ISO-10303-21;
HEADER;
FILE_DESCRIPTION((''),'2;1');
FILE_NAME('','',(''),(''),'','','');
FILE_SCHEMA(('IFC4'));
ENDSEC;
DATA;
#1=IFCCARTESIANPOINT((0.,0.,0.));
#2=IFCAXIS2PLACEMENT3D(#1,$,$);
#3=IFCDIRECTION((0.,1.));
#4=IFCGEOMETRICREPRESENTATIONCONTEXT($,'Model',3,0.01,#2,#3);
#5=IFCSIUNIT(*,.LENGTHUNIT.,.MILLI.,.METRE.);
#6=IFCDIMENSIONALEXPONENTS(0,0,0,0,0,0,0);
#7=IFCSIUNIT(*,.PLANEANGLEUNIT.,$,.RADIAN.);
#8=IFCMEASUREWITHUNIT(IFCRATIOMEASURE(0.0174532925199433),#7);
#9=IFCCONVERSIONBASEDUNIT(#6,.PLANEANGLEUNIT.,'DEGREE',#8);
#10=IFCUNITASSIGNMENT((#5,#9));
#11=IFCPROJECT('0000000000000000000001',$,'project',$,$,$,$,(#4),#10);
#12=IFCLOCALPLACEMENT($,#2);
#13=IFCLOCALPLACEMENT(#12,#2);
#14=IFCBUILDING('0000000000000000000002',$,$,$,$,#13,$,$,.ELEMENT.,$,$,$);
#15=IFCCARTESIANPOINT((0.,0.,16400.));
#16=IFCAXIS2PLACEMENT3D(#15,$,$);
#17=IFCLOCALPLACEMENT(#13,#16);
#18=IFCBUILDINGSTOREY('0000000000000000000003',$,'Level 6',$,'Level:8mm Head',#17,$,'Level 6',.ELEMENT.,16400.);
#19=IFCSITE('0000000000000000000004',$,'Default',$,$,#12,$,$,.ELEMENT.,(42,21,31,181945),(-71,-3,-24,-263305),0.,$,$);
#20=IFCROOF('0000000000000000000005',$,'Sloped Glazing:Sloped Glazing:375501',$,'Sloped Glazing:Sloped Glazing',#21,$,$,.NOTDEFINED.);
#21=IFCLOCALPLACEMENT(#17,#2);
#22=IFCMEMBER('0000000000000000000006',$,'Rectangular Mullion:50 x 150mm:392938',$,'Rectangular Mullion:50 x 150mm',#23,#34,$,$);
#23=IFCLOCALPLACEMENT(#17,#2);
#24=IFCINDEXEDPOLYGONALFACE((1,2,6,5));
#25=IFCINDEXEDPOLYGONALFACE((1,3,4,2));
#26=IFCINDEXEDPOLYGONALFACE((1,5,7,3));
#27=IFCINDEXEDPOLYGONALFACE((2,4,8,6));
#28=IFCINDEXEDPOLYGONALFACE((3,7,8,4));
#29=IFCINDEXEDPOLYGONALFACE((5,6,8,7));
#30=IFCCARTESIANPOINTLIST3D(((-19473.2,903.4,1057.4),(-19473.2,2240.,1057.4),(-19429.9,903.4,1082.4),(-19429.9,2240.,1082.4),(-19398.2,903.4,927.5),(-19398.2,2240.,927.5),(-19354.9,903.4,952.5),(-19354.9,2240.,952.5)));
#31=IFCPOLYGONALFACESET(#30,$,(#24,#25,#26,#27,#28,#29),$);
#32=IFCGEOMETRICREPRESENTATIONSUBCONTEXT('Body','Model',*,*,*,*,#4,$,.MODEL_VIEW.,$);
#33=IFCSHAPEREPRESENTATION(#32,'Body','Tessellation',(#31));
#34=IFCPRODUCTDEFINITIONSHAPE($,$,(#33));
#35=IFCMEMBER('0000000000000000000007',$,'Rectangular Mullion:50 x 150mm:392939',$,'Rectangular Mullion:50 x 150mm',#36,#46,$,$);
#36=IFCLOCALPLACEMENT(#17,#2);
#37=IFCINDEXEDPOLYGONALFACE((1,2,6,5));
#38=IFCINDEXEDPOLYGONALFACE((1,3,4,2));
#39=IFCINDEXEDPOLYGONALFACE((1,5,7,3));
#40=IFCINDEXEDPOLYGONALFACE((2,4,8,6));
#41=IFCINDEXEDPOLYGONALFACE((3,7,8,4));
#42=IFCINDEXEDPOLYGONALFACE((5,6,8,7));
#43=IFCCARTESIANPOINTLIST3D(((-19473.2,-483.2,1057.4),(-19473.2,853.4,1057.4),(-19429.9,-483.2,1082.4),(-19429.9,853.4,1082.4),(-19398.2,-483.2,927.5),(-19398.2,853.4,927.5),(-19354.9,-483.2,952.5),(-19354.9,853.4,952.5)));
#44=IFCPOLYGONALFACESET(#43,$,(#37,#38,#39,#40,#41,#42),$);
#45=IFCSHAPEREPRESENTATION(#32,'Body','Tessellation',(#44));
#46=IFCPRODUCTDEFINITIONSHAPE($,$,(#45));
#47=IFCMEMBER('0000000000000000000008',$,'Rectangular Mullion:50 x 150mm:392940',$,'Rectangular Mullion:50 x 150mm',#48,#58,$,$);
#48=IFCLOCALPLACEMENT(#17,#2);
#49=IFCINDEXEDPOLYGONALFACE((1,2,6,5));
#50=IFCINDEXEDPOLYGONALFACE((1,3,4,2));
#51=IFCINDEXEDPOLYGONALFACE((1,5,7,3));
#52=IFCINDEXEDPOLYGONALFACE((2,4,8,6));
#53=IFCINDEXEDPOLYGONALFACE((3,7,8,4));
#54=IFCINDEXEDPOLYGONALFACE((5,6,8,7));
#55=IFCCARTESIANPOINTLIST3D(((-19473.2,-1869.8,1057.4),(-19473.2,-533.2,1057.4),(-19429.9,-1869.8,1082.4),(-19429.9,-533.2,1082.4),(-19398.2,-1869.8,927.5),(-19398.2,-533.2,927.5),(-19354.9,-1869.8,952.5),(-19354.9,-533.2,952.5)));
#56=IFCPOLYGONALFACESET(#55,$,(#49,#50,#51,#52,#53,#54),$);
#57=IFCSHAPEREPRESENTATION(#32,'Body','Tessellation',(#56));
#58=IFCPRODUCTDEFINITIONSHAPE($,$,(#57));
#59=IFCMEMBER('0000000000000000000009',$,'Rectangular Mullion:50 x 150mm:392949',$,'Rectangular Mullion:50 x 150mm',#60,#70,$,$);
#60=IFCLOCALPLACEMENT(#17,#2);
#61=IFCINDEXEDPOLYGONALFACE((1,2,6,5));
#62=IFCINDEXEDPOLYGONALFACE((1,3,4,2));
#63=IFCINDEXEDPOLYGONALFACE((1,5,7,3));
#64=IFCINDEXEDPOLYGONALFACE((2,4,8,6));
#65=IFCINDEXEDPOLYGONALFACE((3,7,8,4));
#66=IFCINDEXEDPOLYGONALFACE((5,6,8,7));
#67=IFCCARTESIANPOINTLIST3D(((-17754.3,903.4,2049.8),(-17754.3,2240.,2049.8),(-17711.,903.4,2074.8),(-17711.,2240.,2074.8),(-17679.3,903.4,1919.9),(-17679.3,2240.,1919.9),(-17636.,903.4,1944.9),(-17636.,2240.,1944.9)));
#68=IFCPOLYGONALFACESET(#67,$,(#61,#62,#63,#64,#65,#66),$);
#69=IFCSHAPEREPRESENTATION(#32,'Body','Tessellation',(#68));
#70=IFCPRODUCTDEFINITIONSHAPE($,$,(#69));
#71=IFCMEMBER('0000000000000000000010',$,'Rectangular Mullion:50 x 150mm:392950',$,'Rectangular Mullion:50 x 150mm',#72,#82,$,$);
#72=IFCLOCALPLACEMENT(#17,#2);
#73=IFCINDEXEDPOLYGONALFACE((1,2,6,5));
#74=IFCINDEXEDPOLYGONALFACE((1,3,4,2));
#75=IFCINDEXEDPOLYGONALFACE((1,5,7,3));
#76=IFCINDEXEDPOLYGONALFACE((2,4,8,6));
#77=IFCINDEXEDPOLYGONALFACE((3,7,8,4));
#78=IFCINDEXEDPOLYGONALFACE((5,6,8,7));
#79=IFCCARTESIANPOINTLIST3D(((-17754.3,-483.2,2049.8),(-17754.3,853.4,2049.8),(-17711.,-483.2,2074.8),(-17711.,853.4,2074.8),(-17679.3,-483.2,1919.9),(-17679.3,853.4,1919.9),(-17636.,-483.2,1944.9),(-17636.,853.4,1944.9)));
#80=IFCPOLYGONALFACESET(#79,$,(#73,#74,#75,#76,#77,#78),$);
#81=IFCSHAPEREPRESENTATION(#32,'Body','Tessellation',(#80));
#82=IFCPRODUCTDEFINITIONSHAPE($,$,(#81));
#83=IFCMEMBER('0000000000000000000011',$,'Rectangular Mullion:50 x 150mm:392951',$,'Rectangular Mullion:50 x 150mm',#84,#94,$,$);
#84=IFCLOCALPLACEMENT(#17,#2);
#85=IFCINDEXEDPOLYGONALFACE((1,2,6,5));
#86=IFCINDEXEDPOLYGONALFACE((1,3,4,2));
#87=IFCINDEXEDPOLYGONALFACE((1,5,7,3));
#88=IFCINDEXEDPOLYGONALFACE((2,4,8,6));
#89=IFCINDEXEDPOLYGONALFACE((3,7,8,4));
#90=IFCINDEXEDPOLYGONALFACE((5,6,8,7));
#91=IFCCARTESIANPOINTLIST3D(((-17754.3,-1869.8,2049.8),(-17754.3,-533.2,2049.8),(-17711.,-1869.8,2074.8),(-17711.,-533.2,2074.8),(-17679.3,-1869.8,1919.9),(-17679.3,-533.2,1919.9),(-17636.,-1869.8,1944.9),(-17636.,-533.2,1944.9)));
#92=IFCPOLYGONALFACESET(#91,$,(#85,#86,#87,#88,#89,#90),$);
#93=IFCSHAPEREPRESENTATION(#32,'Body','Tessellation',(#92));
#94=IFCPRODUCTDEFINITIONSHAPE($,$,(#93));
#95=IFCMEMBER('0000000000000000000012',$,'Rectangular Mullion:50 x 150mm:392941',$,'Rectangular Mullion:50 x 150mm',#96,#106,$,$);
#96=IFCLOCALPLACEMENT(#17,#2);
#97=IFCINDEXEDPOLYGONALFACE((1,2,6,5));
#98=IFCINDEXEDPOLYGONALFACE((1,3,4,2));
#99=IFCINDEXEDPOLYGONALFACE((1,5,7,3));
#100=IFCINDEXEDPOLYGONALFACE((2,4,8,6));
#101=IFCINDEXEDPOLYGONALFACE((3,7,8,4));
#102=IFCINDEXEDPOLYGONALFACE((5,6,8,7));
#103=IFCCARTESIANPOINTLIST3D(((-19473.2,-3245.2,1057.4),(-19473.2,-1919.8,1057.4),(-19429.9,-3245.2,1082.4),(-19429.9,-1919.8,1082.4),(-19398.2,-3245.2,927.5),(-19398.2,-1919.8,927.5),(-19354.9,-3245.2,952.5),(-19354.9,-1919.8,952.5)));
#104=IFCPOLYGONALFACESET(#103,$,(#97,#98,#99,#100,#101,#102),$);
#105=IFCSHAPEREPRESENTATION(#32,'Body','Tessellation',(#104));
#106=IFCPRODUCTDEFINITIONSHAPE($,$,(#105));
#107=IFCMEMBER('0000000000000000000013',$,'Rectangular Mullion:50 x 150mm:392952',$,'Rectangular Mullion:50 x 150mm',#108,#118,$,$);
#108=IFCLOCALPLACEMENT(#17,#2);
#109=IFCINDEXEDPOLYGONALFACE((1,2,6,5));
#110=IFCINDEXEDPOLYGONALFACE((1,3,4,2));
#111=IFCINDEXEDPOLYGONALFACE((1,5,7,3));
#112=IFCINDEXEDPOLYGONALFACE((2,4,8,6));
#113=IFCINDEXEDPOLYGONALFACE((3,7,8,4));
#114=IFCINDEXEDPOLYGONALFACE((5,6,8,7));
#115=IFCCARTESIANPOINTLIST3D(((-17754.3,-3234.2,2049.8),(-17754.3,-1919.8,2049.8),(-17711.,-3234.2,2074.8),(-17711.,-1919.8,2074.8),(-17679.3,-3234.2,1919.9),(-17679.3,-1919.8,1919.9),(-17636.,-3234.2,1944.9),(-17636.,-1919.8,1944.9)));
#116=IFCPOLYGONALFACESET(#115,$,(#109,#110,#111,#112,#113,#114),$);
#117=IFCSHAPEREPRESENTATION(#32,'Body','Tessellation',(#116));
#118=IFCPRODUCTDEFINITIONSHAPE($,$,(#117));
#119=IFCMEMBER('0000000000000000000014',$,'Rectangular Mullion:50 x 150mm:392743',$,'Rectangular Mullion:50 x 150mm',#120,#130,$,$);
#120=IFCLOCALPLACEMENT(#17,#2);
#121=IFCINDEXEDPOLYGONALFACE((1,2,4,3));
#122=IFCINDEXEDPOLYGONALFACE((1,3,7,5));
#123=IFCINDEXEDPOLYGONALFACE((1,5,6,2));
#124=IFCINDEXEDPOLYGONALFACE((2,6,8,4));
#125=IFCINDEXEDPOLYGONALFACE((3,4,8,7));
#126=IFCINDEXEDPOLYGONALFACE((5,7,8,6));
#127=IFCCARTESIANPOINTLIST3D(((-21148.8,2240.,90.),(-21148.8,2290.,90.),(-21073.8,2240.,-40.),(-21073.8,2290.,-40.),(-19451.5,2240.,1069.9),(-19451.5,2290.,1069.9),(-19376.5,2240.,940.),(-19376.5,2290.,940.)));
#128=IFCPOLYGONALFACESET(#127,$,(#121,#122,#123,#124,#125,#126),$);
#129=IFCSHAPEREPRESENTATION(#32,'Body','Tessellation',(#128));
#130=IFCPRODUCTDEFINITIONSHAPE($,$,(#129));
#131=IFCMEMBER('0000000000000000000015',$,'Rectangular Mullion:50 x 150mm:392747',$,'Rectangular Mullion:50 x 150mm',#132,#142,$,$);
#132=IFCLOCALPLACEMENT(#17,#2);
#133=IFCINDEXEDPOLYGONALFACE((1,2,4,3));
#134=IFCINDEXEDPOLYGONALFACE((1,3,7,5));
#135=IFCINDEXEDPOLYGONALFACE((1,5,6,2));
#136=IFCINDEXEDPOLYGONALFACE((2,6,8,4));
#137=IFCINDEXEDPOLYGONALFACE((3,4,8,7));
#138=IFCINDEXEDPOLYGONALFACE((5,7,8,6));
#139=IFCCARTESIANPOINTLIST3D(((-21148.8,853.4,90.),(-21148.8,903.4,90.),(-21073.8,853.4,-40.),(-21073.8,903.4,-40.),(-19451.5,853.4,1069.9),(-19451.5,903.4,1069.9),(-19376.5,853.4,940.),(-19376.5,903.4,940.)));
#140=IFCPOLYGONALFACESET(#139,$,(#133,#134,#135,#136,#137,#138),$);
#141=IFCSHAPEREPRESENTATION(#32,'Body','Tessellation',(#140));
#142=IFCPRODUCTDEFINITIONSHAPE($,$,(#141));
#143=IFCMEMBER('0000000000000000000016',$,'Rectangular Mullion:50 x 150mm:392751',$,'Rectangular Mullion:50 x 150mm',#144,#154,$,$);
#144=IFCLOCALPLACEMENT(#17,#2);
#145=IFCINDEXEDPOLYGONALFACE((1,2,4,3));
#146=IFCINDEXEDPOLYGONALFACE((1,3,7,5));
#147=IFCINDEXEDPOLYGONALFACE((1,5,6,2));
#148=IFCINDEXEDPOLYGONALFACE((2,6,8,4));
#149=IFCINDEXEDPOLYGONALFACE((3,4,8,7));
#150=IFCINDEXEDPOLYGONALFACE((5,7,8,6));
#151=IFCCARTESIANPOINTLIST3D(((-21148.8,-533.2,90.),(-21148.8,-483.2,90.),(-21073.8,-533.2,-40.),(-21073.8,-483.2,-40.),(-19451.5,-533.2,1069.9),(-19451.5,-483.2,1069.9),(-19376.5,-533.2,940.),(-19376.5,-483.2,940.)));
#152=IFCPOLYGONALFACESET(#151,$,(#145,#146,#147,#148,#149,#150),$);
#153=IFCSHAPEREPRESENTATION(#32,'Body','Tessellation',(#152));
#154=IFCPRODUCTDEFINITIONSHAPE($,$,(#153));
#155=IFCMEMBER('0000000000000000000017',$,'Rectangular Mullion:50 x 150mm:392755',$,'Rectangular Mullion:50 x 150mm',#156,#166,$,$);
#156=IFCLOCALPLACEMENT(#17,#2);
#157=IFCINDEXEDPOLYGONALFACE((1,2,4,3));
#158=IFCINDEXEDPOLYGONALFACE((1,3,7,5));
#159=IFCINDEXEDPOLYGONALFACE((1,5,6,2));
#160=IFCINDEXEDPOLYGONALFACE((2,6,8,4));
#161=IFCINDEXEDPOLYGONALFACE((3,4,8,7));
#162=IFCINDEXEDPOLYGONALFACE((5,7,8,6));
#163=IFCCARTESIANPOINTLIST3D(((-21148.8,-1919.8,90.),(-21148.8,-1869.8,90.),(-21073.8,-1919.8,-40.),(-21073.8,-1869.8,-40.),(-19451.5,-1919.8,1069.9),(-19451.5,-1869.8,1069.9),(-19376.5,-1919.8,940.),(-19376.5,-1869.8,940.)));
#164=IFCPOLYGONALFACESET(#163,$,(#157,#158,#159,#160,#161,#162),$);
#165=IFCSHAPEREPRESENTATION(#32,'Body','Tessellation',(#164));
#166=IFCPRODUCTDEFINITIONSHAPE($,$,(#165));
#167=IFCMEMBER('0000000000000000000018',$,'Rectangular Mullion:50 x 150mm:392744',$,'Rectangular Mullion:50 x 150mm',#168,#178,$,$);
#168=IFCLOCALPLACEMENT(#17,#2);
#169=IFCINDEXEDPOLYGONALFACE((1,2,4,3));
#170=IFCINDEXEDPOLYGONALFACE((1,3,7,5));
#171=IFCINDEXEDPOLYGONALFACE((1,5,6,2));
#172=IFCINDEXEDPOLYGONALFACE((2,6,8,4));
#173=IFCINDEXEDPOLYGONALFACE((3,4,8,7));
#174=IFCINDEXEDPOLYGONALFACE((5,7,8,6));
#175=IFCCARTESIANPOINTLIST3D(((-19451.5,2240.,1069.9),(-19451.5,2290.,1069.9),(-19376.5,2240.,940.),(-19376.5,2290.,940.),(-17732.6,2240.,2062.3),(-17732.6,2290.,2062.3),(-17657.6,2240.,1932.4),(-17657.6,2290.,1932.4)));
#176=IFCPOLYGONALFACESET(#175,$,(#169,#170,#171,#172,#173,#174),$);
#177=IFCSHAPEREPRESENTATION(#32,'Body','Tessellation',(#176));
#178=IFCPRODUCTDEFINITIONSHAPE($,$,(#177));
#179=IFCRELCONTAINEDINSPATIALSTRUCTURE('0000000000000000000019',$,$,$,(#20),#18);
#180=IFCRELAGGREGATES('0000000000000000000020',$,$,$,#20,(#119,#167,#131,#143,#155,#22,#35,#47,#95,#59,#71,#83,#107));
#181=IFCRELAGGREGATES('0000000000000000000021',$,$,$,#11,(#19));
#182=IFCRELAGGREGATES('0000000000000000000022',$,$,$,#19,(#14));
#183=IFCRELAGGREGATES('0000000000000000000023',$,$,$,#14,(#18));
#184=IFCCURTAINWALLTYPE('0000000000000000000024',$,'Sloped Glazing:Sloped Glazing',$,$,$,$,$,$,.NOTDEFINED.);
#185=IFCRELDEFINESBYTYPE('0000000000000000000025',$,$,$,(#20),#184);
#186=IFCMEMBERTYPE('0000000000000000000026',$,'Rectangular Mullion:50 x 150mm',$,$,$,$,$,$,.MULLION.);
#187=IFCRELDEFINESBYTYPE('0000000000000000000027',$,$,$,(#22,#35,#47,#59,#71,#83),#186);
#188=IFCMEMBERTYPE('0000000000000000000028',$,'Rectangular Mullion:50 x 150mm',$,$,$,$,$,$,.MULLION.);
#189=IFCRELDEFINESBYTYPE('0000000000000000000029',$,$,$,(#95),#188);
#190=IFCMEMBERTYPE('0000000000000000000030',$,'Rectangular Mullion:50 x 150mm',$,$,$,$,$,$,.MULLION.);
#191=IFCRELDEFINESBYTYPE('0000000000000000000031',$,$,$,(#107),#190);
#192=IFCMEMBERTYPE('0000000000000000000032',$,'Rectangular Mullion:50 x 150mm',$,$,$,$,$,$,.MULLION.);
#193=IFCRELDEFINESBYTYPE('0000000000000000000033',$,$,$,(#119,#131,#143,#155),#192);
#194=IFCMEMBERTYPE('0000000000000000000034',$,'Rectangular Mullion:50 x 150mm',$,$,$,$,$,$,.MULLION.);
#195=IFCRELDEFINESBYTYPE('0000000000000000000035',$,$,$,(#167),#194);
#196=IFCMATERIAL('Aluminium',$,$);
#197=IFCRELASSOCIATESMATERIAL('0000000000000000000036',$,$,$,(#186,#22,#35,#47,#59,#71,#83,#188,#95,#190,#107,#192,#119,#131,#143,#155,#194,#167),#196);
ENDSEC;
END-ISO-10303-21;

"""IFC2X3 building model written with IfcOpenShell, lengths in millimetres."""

from ifc_helpers import new_model, entity, si_unit, converted_unit, direction, frame, origin, origin_2d_with_axis, place, context, subcontext, project, spatial, rectangle, extrude, source, transform, mapped, material, type_object, type_shapes, element, aggregate, save


model = new_model("IFC2X3")

# Units and contexts
model_context = context("Model", 3, precision=0.01, world=origin(), true_north=direction((0.0, 1.0)))
body_context = subcontext(model_context, "Body", "Model", "MODEL_VIEW")
ifc_project = project(units=[si_unit("LENGTHUNIT", "METRE", prefix="MILLI"), converted_unit("PLANEANGLEUNIT", "DEGREE", entity("IfcRatioMeasure", 0.0174532925199433), si_unit("PLANEANGLEUNIT", "RADIAN"), dimensions=[0, 0, 0, 0, 0, 0, 0])], contexts=[model_context])

# Site, building, storey
site_placement = place(None, frame((0.0, 0.0, 0.0)))
site = spatial("IfcSite", under=ifc_project, at=site_placement, Name="Default", CompositionType="ELEMENT", RefLatitude=(42, 21, 31, 181945), RefLongitude=(-71, -3, -24, -263305), RefElevation=0.0)
building_placement = place(site_placement, origin())
building = spatial("IfcBuilding", under=site, at=building_placement, CompositionType="ELEMENT")
storey_placement = place(building_placement, frame((0.0, 0.0, 16400.0)))
storey = spatial("IfcBuildingStorey", under=building, at=storey_placement, Name="Level 6", ObjectType="Level:8mm Head", LongName="Level 6", CompositionType="ELEMENT", Elevation=16400.0)

# Roof, members
curtain_wall_type = type_object("IfcCurtainWallType", Name="Sloped Glazing:Sloped Glazing", PredefinedType="NOTDEFINED")
roof_placement = place(storey_placement, frame((0.0, 0.0, -16400.0)))
roof = element("IfcRoof", 1, at=roof_placement, inside=storey, type_object=curtain_wall_type, Name="Sloped Glazing:Sloped Glazing:375501", ObjectType="Sloped Glazing:Sloped Glazing", ShapeType="NOTDEFINED")
ifc_material_1 = material(Name="Aluminium")
member_type_1 = type_object("IfcMemberType", Name="Rectangular Mullion:50 x 150mm", PredefinedType="MULLION", material=ifc_material_1)
shared_shape_1 = source(origin(), body_context, "Body", "SweptSolid", [
    extrude(rectangle(XDim=150.0, YDim=50.0, at=origin_2d_with_axis()), frame((0.0, 0.0, -1336.6), z_axis=(0.0, 0.0, 1.0), x_axis=(0.0, -1.0, 0.0)), (0.0, 0.0, 1.0), 1336.6),
])
type_shapes(member_type_1, [shared_shape_1])
member_1_placement = place(storey_placement, frame((-19414.0, 2240.0, 1004.9), z_axis=(0.0, 1.0, 0.0), x_axis=(0.866025, 0.0, 0.5)))
member_1 = element("IfcMember", 2, at=member_1_placement, type_object=member_type_1, material=ifc_material_1, Name="Rectangular Mullion:50 x 150mm:392938", ObjectType="Rectangular Mullion:50 x 150mm", context=body_context, shape_type="MappedRepresentation", body=[
    mapped(shared_shape_1, transform((0.0, 0.0, 0.0), scale=1.0)),
])
member_2_placement = place(storey_placement, frame((-19414.0, 853.4, 1004.9), z_axis=(0.0, 1.0, 0.0), x_axis=(0.866025, 0.0, 0.5)))
member_2 = element("IfcMember", 3, at=member_2_placement, type_object=member_type_1, material=ifc_material_1, Name="Rectangular Mullion:50 x 150mm:392939", ObjectType="Rectangular Mullion:50 x 150mm", context=body_context, shape_type="MappedRepresentation", body=[
    mapped(shared_shape_1, transform((0.0, 0.0, 0.0), scale=1.0)),
])
member_3_placement = place(storey_placement, frame((-19414.0, -533.2, 1004.9), z_axis=(0.0, 1.0, 0.0), x_axis=(0.866025, 0.0, 0.5)))
member_3 = element("IfcMember", 4, at=member_3_placement, type_object=member_type_1, material=ifc_material_1, Name="Rectangular Mullion:50 x 150mm:392940", ObjectType="Rectangular Mullion:50 x 150mm", context=body_context, shape_type="MappedRepresentation", body=[
    mapped(shared_shape_1, transform((0.0, 0.0, 0.0), scale=1.0)),
])
member_4_placement = place(storey_placement, frame((-17695.1, 2240.0, 1997.3), z_axis=(0.0, 1.0, 0.0), x_axis=(0.866025, 0.0, 0.5)))
member_4 = element("IfcMember", 5, at=member_4_placement, type_object=member_type_1, material=ifc_material_1, Name="Rectangular Mullion:50 x 150mm:392949", ObjectType="Rectangular Mullion:50 x 150mm", context=body_context, shape_type="MappedRepresentation", body=[
    mapped(shared_shape_1, transform((0.0, 0.0, 0.0), scale=1.0)),
])
member_5_placement = place(storey_placement, frame((-17695.1, 853.4, 1997.3), z_axis=(0.0, 1.0, 0.0), x_axis=(0.866025, 0.0, 0.5)))
member_5 = element("IfcMember", 6, at=member_5_placement, type_object=member_type_1, material=ifc_material_1, Name="Rectangular Mullion:50 x 150mm:392950", ObjectType="Rectangular Mullion:50 x 150mm", context=body_context, shape_type="MappedRepresentation", body=[
    mapped(shared_shape_1, transform((0.0, 0.0, 0.0), scale=1.0)),
])
member_6_placement = place(storey_placement, frame((-17695.1, -533.2, 1997.3), z_axis=(0.0, 1.0, 0.0), x_axis=(0.866025, 0.0, 0.5)))
member_6 = element("IfcMember", 7, at=member_6_placement, type_object=member_type_1, material=ifc_material_1, Name="Rectangular Mullion:50 x 150mm:392951", ObjectType="Rectangular Mullion:50 x 150mm", context=body_context, shape_type="MappedRepresentation", body=[
    mapped(shared_shape_1, transform((0.0, 0.0, 0.0), scale=1.0)),
])
member_type_2 = type_object("IfcMemberType", Name="Rectangular Mullion:50 x 150mm", PredefinedType="MULLION", material=ifc_material_1)
shared_shape_2 = source(origin(), body_context, "Body", "SweptSolid", [
    extrude(rectangle(XDim=150.0, YDim=50.0, at=origin_2d_with_axis()), frame((0.0, 0.0, -1325.4), z_axis=(0.0, 0.0, 1.0), x_axis=(0.0, -1.0, 0.0)), (0.0, 0.0, 1.0), 1325.4),
])
type_shapes(member_type_2, [shared_shape_2])
member_7_placement = place(storey_placement, frame((-19414.0, -1919.8, 1004.9), z_axis=(0.0, 1.0, 0.0), x_axis=(0.866025, 0.0, 0.5)))
member_7 = element("IfcMember", 8, at=member_7_placement, type_object=member_type_2, material=ifc_material_1, Name="Rectangular Mullion:50 x 150mm:392941", ObjectType="Rectangular Mullion:50 x 150mm", context=body_context, shape_type="MappedRepresentation", body=[
    mapped(shared_shape_2, transform((0.0, 0.0, 0.0), scale=1.0)),
])
member_type_3 = type_object("IfcMemberType", Name="Rectangular Mullion:50 x 150mm", PredefinedType="MULLION", material=ifc_material_1)
shared_shape_3 = source(origin(), body_context, "Body", "SweptSolid", [
    extrude(rectangle(XDim=150.0, YDim=50.0, at=origin_2d_with_axis()), frame((0.0, 0.0, -1314.4), z_axis=(0.0, 0.0, 1.0), x_axis=(0.0, -1.0, 0.0)), (0.0, 0.0, 1.0), 1314.4),
])
type_shapes(member_type_3, [shared_shape_3])
member_8_placement = place(storey_placement, frame((-17695.1, -1919.8, 1997.3), z_axis=(0.0, 1.0, 0.0), x_axis=(0.866025, 0.0, 0.5)))
member_8 = element("IfcMember", 9, at=member_8_placement, type_object=member_type_3, material=ifc_material_1, Name="Rectangular Mullion:50 x 150mm:392952", ObjectType="Rectangular Mullion:50 x 150mm", context=body_context, shape_type="MappedRepresentation", body=[
    mapped(shared_shape_3, transform((0.0, 0.0, 0.0), scale=1.0)),
])
member_type_4 = type_object("IfcMemberType", Name="Rectangular Mullion:50 x 150mm", PredefinedType="MULLION", material=ifc_material_1)
shared_shape_4 = source(origin(), body_context, "Body", "SweptSolid", [
    extrude(rectangle(XDim=150.0, YDim=50.0, at=origin_2d_with_axis()), frame((0.0, 0.0, -1959.8), z_axis=(0.0, 0.0, 1.0), x_axis=(0.0, -1.0, 0.0)), (0.0, 0.0, 1.0), 1959.8),
])
type_shapes(member_type_4, [shared_shape_4])
member_9_placement = place(storey_placement, frame((-19414.0, 2265.0, 1004.9), z_axis=(0.866025, 0.0, 0.5), x_axis=(0.0, -1.0, 0.0)))
member_9 = element("IfcMember", 10, at=member_9_placement, type_object=member_type_4, material=ifc_material_1, Name="Rectangular Mullion:50 x 150mm:392743", ObjectType="Rectangular Mullion:50 x 150mm", context=body_context, shape_type="MappedRepresentation", body=[
    mapped(shared_shape_4, transform((0.0, 0.0, 0.0), scale=1.0)),
])
member_10_placement = place(storey_placement, frame((-19414.0, 878.4, 1004.9), z_axis=(0.866025, 0.0, 0.5), x_axis=(0.0, -1.0, 0.0)))
member_10 = element("IfcMember", 11, at=member_10_placement, type_object=member_type_4, material=ifc_material_1, Name="Rectangular Mullion:50 x 150mm:392747", ObjectType="Rectangular Mullion:50 x 150mm", context=body_context, shape_type="MappedRepresentation", body=[
    mapped(shared_shape_4, transform((0.0, 0.0, 0.0), scale=1.0)),
])
member_11_placement = place(storey_placement, frame((-19414.0, -508.2, 1004.9), z_axis=(0.866025, 0.0, 0.5), x_axis=(0.0, -1.0, 0.0)))
member_11 = element("IfcMember", 12, at=member_11_placement, type_object=member_type_4, material=ifc_material_1, Name="Rectangular Mullion:50 x 150mm:392751", ObjectType="Rectangular Mullion:50 x 150mm", context=body_context, shape_type="MappedRepresentation", body=[
    mapped(shared_shape_4, transform((0.0, 0.0, 0.0), scale=1.0)),
])
member_12_placement = place(storey_placement, frame((-19414.0, -1894.8, 1004.9), z_axis=(0.866025, 0.0, 0.5), x_axis=(0.0, -1.0, 0.0)))
member_12 = element("IfcMember", 13, at=member_12_placement, type_object=member_type_4, material=ifc_material_1, Name="Rectangular Mullion:50 x 150mm:392755", ObjectType="Rectangular Mullion:50 x 150mm", context=body_context, shape_type="MappedRepresentation", body=[
    mapped(shared_shape_4, transform((0.0, 0.0, 0.0), scale=1.0)),
])
member_type_5 = type_object("IfcMemberType", Name="Rectangular Mullion:50 x 150mm", PredefinedType="MULLION", material=ifc_material_1)
shared_shape_5 = source(origin(), body_context, "Body", "SweptSolid", [
    extrude(rectangle(XDim=150.0, YDim=50.0, at=origin_2d_with_axis()), frame((0.0, 0.0, -1984.8), z_axis=(0.0, 0.0, 1.0), x_axis=(0.0, -1.0, 0.0)), (0.0, 0.0, 1.0), 1984.8),
])
type_shapes(member_type_5, [shared_shape_5])
member_13_placement = place(storey_placement, frame((-17695.1, 2265.0, 1997.3), z_axis=(0.866025, 0.0, 0.5), x_axis=(0.0, -1.0, 0.0)))
member_13 = element("IfcMember", 14, at=member_13_placement, type_object=member_type_5, material=ifc_material_1, Name="Rectangular Mullion:50 x 150mm:392744", ObjectType="Rectangular Mullion:50 x 150mm", context=body_context, shape_type="MappedRepresentation", body=[
    mapped(shared_shape_5, transform((0.0, 0.0, 0.0), scale=1.0)),
])
aggregate(roof, [member_9, member_13, member_10, member_11, member_12, member_1, member_2, member_3, member_7, member_4, member_5, member_6, member_8])

save(model, "model.ifc")
